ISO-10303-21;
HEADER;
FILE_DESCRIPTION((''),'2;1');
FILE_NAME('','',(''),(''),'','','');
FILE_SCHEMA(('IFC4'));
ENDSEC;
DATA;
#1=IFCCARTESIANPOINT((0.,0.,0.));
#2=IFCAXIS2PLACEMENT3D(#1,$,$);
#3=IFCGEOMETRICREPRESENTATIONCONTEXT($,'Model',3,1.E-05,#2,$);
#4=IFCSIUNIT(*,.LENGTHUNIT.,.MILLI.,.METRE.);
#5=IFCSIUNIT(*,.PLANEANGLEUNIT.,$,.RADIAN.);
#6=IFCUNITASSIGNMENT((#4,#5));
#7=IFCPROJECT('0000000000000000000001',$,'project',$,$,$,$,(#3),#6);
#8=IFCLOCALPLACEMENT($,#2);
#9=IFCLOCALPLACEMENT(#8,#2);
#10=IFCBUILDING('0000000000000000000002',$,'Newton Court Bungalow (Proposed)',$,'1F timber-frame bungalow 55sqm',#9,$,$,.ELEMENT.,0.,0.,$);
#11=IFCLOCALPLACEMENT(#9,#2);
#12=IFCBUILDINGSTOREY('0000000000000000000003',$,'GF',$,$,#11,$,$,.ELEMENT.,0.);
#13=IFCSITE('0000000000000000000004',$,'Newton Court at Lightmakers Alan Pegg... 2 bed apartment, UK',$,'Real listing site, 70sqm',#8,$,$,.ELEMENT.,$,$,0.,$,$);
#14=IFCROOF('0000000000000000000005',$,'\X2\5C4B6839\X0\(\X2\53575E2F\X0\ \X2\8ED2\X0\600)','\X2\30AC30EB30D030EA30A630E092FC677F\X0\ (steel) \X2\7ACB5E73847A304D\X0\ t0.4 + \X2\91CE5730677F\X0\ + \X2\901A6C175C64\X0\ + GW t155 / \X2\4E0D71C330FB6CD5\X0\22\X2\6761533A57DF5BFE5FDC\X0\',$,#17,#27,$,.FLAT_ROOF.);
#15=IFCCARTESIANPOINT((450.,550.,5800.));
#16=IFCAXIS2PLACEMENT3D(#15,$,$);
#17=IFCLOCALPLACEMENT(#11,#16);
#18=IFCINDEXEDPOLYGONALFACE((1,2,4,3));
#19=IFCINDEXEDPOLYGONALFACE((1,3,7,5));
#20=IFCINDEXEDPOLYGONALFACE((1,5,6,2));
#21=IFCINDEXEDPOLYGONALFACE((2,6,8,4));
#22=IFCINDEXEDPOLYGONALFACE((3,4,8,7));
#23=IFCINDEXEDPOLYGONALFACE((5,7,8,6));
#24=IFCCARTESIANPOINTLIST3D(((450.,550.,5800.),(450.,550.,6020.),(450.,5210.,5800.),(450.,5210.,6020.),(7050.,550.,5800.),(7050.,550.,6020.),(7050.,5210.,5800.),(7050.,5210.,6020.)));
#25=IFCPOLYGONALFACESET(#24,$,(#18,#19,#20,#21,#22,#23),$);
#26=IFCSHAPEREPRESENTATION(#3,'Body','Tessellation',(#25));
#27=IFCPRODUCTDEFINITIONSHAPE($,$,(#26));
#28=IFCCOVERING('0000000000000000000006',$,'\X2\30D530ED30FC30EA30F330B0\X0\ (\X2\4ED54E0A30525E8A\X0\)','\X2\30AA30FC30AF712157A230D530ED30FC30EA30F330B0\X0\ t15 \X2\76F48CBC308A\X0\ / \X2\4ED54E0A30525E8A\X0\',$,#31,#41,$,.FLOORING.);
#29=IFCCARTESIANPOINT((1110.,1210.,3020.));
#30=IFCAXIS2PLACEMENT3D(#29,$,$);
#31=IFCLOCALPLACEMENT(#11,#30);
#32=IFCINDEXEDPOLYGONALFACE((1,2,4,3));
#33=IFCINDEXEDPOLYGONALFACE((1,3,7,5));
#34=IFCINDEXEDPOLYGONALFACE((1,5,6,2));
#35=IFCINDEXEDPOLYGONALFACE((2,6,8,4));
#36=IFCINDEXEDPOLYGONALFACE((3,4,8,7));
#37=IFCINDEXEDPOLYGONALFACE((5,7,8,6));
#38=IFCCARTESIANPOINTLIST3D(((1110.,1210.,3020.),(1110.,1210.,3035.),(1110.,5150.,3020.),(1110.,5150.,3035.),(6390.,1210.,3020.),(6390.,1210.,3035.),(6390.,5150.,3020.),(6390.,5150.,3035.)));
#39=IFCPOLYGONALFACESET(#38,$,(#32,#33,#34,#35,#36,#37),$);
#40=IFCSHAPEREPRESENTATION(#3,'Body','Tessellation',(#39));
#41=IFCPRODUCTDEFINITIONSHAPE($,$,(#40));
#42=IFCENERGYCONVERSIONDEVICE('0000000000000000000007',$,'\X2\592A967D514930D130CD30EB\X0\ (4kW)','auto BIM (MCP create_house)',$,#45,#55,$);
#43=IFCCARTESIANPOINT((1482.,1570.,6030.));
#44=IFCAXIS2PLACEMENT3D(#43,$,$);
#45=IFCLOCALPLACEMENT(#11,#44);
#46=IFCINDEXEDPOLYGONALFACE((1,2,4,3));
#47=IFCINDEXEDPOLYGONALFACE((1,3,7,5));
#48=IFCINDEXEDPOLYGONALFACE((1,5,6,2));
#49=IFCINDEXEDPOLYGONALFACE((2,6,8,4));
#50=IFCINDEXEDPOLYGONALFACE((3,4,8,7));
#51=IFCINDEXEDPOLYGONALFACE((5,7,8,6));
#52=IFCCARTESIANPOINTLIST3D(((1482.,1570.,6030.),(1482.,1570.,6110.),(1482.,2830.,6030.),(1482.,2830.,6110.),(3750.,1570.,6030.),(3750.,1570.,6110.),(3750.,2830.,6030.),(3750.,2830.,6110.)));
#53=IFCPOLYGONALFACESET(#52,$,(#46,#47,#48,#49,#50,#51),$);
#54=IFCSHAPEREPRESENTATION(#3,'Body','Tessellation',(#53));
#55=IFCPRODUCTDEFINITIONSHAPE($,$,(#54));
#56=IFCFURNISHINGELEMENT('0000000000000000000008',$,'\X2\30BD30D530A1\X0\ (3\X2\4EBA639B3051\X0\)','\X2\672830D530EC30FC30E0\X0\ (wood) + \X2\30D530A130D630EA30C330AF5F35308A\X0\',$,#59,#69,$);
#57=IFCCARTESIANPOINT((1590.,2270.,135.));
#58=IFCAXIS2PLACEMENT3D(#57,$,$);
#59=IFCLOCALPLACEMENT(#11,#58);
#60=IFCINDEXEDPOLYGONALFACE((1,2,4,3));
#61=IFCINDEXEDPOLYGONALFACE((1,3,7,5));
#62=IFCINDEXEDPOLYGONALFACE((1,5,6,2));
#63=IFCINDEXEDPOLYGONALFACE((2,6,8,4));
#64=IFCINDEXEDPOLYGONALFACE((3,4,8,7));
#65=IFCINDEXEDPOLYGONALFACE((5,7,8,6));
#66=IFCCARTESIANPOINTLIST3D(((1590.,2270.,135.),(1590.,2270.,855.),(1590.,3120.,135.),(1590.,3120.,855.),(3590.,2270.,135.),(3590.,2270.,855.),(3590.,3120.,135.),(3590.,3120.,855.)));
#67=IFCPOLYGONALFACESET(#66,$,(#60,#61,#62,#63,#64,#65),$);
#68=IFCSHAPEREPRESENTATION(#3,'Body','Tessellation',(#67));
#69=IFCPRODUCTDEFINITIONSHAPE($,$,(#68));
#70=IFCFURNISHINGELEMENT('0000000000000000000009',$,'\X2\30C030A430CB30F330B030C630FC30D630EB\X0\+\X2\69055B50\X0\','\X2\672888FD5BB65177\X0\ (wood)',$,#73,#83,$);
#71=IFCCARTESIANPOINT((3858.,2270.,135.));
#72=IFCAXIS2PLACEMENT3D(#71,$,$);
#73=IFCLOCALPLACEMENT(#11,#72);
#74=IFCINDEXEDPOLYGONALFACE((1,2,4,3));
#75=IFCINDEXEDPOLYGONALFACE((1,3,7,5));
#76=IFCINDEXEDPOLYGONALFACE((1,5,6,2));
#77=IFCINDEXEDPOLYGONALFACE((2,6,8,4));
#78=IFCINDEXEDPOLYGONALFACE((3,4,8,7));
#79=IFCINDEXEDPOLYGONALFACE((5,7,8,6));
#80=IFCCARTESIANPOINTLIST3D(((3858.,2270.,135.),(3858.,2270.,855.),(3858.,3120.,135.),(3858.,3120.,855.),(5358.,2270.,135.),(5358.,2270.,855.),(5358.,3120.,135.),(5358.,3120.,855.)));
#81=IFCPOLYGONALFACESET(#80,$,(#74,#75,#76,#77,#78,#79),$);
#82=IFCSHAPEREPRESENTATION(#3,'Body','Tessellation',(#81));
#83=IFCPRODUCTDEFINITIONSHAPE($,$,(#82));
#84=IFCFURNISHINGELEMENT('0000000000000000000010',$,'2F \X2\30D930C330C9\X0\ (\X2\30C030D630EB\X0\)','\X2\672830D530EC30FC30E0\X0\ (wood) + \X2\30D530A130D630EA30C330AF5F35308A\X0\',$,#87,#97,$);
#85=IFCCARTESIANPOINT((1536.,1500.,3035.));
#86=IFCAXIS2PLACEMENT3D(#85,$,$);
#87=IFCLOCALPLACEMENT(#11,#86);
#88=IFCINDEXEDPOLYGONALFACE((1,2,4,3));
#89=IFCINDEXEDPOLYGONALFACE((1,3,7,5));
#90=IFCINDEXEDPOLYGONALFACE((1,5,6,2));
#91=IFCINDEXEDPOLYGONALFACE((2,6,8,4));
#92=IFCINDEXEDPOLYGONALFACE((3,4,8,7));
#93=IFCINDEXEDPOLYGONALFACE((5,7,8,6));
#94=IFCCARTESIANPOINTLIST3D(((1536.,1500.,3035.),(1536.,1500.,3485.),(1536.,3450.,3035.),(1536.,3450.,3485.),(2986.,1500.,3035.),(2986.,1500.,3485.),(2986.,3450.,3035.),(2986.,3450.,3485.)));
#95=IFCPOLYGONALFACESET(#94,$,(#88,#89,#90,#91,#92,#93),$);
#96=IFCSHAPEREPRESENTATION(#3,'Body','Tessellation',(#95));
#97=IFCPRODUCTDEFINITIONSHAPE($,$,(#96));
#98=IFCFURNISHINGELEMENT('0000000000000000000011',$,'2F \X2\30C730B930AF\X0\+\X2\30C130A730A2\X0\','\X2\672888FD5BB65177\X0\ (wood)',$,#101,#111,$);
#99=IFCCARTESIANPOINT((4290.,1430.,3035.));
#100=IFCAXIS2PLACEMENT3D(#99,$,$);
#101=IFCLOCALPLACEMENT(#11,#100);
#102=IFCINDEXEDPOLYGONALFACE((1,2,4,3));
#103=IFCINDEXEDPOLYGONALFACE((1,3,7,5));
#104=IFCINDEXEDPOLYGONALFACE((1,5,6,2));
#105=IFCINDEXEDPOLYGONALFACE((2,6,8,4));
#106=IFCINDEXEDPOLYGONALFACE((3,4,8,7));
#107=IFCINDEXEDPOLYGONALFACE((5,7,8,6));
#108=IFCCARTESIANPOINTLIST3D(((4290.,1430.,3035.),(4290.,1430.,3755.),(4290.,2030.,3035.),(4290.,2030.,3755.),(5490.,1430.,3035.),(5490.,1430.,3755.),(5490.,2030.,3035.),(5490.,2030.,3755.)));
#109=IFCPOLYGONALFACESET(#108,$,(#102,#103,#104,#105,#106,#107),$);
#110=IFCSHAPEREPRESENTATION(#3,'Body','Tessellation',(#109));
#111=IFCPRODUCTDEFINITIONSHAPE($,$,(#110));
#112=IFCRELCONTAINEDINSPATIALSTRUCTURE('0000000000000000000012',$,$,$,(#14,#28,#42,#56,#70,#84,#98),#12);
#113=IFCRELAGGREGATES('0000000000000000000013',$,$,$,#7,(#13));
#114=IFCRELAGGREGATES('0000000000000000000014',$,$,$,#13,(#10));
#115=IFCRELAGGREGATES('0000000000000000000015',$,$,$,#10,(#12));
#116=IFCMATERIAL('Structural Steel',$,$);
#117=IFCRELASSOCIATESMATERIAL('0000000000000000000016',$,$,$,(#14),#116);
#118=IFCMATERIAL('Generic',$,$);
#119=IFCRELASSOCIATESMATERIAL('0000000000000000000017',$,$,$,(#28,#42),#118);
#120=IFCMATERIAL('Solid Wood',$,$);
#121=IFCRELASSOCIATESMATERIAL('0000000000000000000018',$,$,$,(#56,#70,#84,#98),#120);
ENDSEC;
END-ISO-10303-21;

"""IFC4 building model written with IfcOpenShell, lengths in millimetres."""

from ifc_helpers import new_model, si_unit, frame, frame_2d, origin, place, context, project, spatial, rectangle, extrude, material, element, save


model = new_model("IFC4")

# Units and contexts
model_context = context("Model", 3, precision=1e-05, world=origin())
ifc_project = project(units=[si_unit("LENGTHUNIT", "METRE", prefix="MILLI"), si_unit("PLANEANGLEUNIT", "RADIAN")], contexts=[model_context])

# Site, building, storey
site_placement = place(None, origin())
site = spatial("IfcSite", under=ifc_project, at=site_placement, Name="Newton Court at Lightmakers Alan Pegg... 2 bed apartment, UK", ObjectType="Real listing site, 70sqm", CompositionType="ELEMENT", RefElevation=0.0)
building_placement = place(site_placement, origin())
building = spatial("IfcBuilding", under=site, at=building_placement, Name="Newton Court Bungalow (Proposed)", ObjectType="1F timber-frame bungalow 55sqm", CompositionType="ELEMENT", ElevationOfRefHeight=0.0, ElevationOfTerrain=0.0)
storey_placement = place(building_placement, origin())
storey = spatial("IfcBuildingStorey", under=building, at=storey_placement, Name="GF", CompositionType="ELEMENT", Elevation=0.0)

# Shared definitions
ifc_material_1 = material(Name="Solid Wood")

# Shared definitions
ifc_material_2 = material(Name="Generic")

# Roof
ifc_material_3 = material(Name="Structural Steel")
for number, where, name in (
    (1, (450.0, 550.0, 5800.0), "屋根(南帯 軒600)"),
):
    element("IfcRoof", number, at=place(storey_placement, frame(where)), inside=storey, material=ifc_material_3, Name=name, Description="ガルバリウム鋼板 (steel) 立平葺き t0.4 + 野地板 + 通気層 + GW t155 / 不燃・法22条区域対応", PredefinedType="FLAT_ROOF", context=model_context, shape_type="SweptSolid", body=[
        extrude(rectangle(XDim=6600.0, YDim=4660.0, at=frame_2d((3300.0, 2330.0))), frame((450.0, 550.0, 5800.0)), (0.0, 0.0, 1.0), 220.0),
    ])

# Covering
covering_placement = place(storey_placement, frame((1110.0, 1210.0, 3020.0)))
element("IfcCovering", 2, at=covering_placement, inside=storey, material=ifc_material_2, Name="フローリング (仕上げ床)", Description="オーク無垢フローリング t15 直貼り / 仕上げ床", PredefinedType="FLOORING", context=model_context, shape_type="SweptSolid", body=[
    extrude(rectangle(XDim=5280.0, YDim=3940.0, at=frame_2d((2640.0, 1970.0))), frame((1110.0, 1210.0, 3020.0)), (0.0, 0.0, 1.0), 15.0),
])

# Energy conversion device
energy_conversion_device_placement = place(storey_placement, frame((1482.0, 1570.0, 6030.0)))
element("IfcEnergyConversionDevice", 3, at=energy_conversion_device_placement, inside=storey, material=ifc_material_2, Name="太陽光パネル (4kW)", Description="auto BIM (MCP create_house)", context=model_context, shape_type="SweptSolid", body=[
    extrude(rectangle(XDim=2268.0, YDim=1260.0, at=frame_2d((1134.0, 630.0))), frame((1482.0, 1570.0, 6030.0)), (0.0, 0.0, 1.0), 80.0),
])

# Furnishing elements
furnishing_1_placement = place(storey_placement, frame((1590.0, 2270.0, 135.0)))
element("IfcFurnishingElement", 4, at=furnishing_1_placement, inside=storey, material=ifc_material_1, Name="ソファ (3人掛け)", Description="木フレーム (wood) + ファブリック張り", context=model_context, shape_type="SweptSolid", body=[
    extrude(rectangle(XDim=2000.0, YDim=850.0, at=frame_2d((1000.0, 425.0))), frame((1590.0, 2270.0, 135.0)), (0.0, 0.0, 1.0), 720.0),
])
furnishing_2_placement = place(storey_placement, frame((3858.0, 2270.0, 135.0)))
element("IfcFurnishingElement", 5, at=furnishing_2_placement, inside=storey, material=ifc_material_1, Name="ダイニングテーブル+椅子", Description="木製家具 (wood)", context=model_context, shape_type="SweptSolid", body=[
    extrude(rectangle(XDim=1500.0, YDim=850.0, at=frame_2d((750.0, 425.0))), frame((3858.0, 2270.0, 135.0)), (0.0, 0.0, 1.0), 720.0),
])
furnishing_3_placement = place(storey_placement, frame((1536.0, 1500.0, 3035.0)))
element("IfcFurnishingElement", 6, at=furnishing_3_placement, inside=storey, material=ifc_material_1, Name="2F ベッド (ダブル)", Description="木フレーム (wood) + ファブリック張り", context=model_context, shape_type="SweptSolid", body=[
    extrude(rectangle(XDim=1450.0, YDim=1950.0, at=frame_2d((725.0, 975.0))), frame((1536.0, 1500.0, 3035.0)), (0.0, 0.0, 1.0), 450.0),
])
furnishing_4_placement = place(storey_placement, frame((4290.0, 1430.0, 3035.0)))
element("IfcFurnishingElement", 7, at=furnishing_4_placement, inside=storey, material=ifc_material_1, Name="2F デスク+チェア", Description="木製家具 (wood)", context=model_context, shape_type="SweptSolid", body=[
    extrude(rectangle(XDim=1200.0, YDim=600.0, at=frame_2d((600.0, 300.0))), frame((4290.0, 1430.0, 3035.0)), (0.0, 0.0, 1.0), 720.0),
])

save(model, "model.ifc")
